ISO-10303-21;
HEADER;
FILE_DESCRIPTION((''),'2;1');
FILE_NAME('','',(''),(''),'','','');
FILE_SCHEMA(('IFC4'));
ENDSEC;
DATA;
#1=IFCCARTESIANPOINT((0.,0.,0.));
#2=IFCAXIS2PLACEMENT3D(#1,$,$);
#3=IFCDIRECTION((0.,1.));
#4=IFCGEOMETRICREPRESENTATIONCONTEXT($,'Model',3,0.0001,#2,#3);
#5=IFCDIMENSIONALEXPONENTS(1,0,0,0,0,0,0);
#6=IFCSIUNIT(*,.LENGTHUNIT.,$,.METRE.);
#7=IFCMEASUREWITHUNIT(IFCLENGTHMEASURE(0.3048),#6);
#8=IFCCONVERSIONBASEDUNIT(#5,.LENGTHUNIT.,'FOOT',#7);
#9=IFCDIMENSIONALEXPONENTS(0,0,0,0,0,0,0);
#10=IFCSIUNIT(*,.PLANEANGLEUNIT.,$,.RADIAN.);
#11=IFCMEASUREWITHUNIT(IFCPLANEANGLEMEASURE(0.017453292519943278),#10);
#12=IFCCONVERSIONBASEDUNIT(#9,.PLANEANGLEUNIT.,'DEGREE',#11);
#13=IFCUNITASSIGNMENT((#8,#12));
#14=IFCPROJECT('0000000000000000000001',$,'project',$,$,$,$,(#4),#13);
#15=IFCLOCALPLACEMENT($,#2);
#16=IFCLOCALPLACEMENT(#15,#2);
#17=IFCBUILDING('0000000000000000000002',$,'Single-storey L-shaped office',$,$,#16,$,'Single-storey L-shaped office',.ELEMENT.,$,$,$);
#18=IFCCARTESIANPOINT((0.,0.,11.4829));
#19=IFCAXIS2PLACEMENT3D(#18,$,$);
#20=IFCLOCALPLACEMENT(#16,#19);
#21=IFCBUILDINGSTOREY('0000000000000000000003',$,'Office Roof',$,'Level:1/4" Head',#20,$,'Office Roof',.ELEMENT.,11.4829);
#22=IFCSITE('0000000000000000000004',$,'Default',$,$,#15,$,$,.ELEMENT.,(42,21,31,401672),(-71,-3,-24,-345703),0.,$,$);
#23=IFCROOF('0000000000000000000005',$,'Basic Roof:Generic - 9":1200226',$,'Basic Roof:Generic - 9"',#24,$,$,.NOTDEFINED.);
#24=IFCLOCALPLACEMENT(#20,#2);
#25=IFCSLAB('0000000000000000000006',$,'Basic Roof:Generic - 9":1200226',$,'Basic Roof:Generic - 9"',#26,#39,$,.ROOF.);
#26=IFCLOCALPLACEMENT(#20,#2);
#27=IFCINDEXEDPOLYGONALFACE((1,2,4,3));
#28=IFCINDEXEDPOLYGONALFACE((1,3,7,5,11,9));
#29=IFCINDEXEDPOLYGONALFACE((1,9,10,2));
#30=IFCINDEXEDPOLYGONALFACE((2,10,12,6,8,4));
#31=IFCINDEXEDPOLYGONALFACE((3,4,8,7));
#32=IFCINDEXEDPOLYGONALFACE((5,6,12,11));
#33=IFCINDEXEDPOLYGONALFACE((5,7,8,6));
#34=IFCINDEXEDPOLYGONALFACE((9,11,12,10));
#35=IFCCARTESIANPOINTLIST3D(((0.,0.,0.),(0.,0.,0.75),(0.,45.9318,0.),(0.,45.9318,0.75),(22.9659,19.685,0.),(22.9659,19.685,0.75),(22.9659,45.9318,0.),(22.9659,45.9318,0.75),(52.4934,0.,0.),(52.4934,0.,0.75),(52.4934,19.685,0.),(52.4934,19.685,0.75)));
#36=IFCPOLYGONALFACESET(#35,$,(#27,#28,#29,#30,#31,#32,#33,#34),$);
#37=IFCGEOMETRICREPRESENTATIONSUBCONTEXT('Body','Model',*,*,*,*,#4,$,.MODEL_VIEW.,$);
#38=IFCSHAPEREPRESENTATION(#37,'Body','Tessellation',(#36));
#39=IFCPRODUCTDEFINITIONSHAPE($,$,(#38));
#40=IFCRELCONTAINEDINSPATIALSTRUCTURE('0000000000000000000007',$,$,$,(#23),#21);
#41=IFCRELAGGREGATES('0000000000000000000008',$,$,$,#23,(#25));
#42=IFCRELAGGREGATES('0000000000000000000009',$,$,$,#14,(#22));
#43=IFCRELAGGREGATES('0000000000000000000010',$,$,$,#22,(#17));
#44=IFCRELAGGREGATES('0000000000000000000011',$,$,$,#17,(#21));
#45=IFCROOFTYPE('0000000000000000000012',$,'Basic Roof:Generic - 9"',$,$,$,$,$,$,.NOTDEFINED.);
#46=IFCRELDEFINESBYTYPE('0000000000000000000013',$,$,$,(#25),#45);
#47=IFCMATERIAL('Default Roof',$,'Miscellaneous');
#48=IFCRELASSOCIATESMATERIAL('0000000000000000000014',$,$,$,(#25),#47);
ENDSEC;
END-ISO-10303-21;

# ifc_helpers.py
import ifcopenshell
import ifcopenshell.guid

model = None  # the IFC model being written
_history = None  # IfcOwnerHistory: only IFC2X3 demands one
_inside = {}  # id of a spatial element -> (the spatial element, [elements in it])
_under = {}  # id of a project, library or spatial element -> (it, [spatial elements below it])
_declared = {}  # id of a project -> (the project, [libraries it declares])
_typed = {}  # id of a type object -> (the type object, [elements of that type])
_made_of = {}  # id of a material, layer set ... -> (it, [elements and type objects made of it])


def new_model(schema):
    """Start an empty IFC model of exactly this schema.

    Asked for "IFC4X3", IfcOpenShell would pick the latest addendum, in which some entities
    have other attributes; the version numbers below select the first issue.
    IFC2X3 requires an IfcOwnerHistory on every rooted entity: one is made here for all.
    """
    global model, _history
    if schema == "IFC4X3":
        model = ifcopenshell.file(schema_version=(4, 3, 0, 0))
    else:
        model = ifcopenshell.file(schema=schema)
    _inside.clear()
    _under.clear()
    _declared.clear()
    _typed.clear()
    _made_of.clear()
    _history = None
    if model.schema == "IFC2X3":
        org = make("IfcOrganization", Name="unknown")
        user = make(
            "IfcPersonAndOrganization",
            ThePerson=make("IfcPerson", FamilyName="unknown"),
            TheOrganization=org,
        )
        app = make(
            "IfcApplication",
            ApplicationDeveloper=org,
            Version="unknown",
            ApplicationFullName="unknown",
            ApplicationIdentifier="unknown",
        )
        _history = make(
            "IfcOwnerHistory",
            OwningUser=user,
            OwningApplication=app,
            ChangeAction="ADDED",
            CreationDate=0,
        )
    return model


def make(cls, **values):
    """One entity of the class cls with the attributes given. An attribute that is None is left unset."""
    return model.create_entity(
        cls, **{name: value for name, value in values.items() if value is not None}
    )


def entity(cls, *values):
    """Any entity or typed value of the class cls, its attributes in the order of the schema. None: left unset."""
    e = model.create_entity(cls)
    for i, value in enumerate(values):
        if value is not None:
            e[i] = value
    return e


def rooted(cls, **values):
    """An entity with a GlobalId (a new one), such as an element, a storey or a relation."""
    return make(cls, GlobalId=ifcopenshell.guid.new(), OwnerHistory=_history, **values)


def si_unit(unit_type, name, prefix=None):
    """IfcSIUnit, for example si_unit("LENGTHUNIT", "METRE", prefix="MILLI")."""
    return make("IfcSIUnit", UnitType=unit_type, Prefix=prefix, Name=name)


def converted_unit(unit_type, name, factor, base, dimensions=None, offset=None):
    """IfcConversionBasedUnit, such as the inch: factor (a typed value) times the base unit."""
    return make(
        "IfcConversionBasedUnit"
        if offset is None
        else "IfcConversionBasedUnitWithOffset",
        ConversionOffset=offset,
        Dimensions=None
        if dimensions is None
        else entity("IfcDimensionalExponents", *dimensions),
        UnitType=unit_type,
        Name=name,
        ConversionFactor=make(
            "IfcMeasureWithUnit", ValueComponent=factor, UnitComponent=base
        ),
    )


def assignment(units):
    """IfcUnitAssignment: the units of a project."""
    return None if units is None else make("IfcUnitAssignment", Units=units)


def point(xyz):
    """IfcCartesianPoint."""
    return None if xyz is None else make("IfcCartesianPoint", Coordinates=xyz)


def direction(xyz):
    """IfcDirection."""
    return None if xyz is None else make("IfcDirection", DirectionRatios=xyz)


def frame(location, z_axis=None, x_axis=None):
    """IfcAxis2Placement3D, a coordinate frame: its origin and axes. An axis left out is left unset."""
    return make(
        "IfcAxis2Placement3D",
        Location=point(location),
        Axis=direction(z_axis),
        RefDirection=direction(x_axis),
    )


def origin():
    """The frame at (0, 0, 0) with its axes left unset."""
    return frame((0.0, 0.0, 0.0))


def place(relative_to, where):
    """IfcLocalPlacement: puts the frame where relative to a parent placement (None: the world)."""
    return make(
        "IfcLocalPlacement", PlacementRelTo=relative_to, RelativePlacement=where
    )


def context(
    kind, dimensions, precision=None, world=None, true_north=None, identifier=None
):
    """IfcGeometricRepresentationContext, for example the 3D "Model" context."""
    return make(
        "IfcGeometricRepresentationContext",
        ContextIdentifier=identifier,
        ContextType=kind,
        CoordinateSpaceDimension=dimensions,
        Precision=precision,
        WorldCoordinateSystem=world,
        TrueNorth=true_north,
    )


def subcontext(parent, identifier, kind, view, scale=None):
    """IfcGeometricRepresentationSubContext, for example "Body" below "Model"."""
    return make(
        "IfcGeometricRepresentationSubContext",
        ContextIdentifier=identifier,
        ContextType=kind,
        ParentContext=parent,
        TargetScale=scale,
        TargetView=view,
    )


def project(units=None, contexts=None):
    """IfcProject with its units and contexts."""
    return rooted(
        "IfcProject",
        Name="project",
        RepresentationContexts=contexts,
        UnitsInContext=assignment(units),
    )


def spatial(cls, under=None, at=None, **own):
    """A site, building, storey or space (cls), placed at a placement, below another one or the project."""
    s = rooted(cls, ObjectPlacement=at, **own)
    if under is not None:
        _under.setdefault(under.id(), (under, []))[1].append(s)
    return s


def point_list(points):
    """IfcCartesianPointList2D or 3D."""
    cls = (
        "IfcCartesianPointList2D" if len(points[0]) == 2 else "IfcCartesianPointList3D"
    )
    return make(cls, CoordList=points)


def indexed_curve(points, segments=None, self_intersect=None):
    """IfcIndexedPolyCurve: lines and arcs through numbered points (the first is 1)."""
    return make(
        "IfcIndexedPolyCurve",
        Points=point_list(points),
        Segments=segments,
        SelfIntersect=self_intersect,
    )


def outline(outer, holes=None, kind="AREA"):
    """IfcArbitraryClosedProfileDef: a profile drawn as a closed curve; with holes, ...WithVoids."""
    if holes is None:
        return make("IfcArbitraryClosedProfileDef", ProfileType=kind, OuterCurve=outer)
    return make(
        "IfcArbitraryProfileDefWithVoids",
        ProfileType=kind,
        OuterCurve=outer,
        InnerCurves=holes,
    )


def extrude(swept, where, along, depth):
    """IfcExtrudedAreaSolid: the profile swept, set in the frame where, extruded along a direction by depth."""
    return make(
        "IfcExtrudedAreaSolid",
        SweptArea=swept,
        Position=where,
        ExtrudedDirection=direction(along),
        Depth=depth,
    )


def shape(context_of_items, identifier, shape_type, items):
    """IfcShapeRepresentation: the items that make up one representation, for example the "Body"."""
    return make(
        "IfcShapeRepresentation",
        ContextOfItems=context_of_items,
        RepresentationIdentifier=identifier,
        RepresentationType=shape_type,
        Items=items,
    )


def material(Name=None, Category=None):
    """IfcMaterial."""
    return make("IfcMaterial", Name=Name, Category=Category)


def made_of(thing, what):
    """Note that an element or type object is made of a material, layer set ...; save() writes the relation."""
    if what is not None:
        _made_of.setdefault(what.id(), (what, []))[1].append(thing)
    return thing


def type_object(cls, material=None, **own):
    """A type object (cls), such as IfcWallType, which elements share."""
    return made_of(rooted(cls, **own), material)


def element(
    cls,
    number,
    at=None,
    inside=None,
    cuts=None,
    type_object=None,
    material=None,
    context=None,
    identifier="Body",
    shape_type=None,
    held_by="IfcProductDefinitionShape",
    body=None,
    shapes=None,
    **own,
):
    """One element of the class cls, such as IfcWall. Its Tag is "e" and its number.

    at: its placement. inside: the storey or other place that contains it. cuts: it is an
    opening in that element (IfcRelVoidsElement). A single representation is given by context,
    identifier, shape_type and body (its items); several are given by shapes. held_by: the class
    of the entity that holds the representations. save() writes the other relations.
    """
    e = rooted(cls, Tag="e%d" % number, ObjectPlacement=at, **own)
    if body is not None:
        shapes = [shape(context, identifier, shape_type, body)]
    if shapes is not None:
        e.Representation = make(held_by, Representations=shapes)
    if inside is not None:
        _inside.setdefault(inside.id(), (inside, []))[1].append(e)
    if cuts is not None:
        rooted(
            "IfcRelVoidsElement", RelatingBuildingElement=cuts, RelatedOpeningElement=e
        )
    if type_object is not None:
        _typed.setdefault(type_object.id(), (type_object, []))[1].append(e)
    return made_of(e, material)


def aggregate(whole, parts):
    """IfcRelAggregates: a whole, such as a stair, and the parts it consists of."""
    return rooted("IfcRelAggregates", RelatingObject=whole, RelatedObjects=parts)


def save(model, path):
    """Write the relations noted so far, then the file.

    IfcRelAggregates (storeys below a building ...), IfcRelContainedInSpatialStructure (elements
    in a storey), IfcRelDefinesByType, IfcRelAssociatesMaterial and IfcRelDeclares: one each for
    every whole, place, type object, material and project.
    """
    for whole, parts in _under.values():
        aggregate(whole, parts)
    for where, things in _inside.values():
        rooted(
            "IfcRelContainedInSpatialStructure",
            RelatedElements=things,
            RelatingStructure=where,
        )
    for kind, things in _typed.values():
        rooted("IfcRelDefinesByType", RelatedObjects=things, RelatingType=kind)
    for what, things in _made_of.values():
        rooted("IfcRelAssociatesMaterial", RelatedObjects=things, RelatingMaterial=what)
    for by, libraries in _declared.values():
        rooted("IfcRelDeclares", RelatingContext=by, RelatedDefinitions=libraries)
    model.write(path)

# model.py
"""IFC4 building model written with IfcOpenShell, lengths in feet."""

from ifc_helpers import new_model, entity, si_unit, converted_unit, direction, frame, origin, place, context, subcontext, project, spatial, indexed_curve, outline, extrude, material, type_object, element, aggregate, save


model = new_model("IFC4")

# Units and contexts
model_context = context("Model", 3, precision=0.0001, world=origin(), true_north=direction((0.0, 1.0)))
body_context = subcontext(model_context, "Body", "Model", "MODEL_VIEW")
ifc_project = project(units=[converted_unit("LENGTHUNIT", "FOOT", entity("IfcLengthMeasure", 0.3048), si_unit("LENGTHUNIT", "METRE"), dimensions=[1, 0, 0, 0, 0, 0, 0]), converted_unit("PLANEANGLEUNIT", "DEGREE", entity("IfcPlaneAngleMeasure", 0.017453292519943278), si_unit("PLANEANGLEUNIT", "RADIAN"), dimensions=[0, 0, 0, 0, 0, 0, 0])], contexts=[model_context])

# Site, building, storey
site_placement = place(None, origin())
site = spatial("IfcSite", under=ifc_project, at=site_placement, Name="Default", CompositionType="ELEMENT", RefLatitude=(42, 21, 31, 401672), RefLongitude=(-71, -3, -24, -345703), RefElevation=0.0)
building_placement = place(site_placement, origin())
building = spatial("IfcBuilding", under=site, at=building_placement, Name="Single-storey L-shaped office", LongName="Single-storey L-shaped office", CompositionType="ELEMENT")
storey_placement = place(building_placement, frame((0.0, 0.0, 11.4829)))
storey = spatial("IfcBuildingStorey", under=building, at=storey_placement, Name="Office Roof", ObjectType="Level:1/4\" Head", LongName="Office Roof", CompositionType="ELEMENT", Elevation=11.4829)

# Roof, slab
roof_placement = place(storey_placement, origin())
roof = element("IfcRoof", 1, at=roof_placement, inside=storey, Name="Basic Roof:Generic - 9\":1200226", ObjectType="Basic Roof:Generic - 9\"", PredefinedType="NOTDEFINED")
ifc_material = material(Name="Default Roof", Category="Miscellaneous")
roof_type = type_object("IfcRoofType", Name="Basic Roof:Generic - 9\"", PredefinedType="NOTDEFINED")
slab_placement = place(roof_placement, origin())
slab = element("IfcSlab", 2, at=slab_placement, type_object=roof_type, material=ifc_material, Name="Basic Roof:Generic - 9\":1200226", ObjectType="Basic Roof:Generic - 9\"", PredefinedType="ROOF", context=body_context, shape_type="SweptSolid", body=[
    extrude(outline(indexed_curve([(26.2467, -22.9659), (26.2467, -3.2808), (-3.2808, -3.2808), (-3.2808, 22.9659), (-26.2467, 22.9659), (-26.2467, -22.9659), (26.2467, -22.9659)], self_intersect=False)), frame((26.2467, 22.9659, 0.0)), (0.0, 0.0, 1.0), 0.75),
])
aggregate(roof, [slab])

save(model, "model.ifc")
